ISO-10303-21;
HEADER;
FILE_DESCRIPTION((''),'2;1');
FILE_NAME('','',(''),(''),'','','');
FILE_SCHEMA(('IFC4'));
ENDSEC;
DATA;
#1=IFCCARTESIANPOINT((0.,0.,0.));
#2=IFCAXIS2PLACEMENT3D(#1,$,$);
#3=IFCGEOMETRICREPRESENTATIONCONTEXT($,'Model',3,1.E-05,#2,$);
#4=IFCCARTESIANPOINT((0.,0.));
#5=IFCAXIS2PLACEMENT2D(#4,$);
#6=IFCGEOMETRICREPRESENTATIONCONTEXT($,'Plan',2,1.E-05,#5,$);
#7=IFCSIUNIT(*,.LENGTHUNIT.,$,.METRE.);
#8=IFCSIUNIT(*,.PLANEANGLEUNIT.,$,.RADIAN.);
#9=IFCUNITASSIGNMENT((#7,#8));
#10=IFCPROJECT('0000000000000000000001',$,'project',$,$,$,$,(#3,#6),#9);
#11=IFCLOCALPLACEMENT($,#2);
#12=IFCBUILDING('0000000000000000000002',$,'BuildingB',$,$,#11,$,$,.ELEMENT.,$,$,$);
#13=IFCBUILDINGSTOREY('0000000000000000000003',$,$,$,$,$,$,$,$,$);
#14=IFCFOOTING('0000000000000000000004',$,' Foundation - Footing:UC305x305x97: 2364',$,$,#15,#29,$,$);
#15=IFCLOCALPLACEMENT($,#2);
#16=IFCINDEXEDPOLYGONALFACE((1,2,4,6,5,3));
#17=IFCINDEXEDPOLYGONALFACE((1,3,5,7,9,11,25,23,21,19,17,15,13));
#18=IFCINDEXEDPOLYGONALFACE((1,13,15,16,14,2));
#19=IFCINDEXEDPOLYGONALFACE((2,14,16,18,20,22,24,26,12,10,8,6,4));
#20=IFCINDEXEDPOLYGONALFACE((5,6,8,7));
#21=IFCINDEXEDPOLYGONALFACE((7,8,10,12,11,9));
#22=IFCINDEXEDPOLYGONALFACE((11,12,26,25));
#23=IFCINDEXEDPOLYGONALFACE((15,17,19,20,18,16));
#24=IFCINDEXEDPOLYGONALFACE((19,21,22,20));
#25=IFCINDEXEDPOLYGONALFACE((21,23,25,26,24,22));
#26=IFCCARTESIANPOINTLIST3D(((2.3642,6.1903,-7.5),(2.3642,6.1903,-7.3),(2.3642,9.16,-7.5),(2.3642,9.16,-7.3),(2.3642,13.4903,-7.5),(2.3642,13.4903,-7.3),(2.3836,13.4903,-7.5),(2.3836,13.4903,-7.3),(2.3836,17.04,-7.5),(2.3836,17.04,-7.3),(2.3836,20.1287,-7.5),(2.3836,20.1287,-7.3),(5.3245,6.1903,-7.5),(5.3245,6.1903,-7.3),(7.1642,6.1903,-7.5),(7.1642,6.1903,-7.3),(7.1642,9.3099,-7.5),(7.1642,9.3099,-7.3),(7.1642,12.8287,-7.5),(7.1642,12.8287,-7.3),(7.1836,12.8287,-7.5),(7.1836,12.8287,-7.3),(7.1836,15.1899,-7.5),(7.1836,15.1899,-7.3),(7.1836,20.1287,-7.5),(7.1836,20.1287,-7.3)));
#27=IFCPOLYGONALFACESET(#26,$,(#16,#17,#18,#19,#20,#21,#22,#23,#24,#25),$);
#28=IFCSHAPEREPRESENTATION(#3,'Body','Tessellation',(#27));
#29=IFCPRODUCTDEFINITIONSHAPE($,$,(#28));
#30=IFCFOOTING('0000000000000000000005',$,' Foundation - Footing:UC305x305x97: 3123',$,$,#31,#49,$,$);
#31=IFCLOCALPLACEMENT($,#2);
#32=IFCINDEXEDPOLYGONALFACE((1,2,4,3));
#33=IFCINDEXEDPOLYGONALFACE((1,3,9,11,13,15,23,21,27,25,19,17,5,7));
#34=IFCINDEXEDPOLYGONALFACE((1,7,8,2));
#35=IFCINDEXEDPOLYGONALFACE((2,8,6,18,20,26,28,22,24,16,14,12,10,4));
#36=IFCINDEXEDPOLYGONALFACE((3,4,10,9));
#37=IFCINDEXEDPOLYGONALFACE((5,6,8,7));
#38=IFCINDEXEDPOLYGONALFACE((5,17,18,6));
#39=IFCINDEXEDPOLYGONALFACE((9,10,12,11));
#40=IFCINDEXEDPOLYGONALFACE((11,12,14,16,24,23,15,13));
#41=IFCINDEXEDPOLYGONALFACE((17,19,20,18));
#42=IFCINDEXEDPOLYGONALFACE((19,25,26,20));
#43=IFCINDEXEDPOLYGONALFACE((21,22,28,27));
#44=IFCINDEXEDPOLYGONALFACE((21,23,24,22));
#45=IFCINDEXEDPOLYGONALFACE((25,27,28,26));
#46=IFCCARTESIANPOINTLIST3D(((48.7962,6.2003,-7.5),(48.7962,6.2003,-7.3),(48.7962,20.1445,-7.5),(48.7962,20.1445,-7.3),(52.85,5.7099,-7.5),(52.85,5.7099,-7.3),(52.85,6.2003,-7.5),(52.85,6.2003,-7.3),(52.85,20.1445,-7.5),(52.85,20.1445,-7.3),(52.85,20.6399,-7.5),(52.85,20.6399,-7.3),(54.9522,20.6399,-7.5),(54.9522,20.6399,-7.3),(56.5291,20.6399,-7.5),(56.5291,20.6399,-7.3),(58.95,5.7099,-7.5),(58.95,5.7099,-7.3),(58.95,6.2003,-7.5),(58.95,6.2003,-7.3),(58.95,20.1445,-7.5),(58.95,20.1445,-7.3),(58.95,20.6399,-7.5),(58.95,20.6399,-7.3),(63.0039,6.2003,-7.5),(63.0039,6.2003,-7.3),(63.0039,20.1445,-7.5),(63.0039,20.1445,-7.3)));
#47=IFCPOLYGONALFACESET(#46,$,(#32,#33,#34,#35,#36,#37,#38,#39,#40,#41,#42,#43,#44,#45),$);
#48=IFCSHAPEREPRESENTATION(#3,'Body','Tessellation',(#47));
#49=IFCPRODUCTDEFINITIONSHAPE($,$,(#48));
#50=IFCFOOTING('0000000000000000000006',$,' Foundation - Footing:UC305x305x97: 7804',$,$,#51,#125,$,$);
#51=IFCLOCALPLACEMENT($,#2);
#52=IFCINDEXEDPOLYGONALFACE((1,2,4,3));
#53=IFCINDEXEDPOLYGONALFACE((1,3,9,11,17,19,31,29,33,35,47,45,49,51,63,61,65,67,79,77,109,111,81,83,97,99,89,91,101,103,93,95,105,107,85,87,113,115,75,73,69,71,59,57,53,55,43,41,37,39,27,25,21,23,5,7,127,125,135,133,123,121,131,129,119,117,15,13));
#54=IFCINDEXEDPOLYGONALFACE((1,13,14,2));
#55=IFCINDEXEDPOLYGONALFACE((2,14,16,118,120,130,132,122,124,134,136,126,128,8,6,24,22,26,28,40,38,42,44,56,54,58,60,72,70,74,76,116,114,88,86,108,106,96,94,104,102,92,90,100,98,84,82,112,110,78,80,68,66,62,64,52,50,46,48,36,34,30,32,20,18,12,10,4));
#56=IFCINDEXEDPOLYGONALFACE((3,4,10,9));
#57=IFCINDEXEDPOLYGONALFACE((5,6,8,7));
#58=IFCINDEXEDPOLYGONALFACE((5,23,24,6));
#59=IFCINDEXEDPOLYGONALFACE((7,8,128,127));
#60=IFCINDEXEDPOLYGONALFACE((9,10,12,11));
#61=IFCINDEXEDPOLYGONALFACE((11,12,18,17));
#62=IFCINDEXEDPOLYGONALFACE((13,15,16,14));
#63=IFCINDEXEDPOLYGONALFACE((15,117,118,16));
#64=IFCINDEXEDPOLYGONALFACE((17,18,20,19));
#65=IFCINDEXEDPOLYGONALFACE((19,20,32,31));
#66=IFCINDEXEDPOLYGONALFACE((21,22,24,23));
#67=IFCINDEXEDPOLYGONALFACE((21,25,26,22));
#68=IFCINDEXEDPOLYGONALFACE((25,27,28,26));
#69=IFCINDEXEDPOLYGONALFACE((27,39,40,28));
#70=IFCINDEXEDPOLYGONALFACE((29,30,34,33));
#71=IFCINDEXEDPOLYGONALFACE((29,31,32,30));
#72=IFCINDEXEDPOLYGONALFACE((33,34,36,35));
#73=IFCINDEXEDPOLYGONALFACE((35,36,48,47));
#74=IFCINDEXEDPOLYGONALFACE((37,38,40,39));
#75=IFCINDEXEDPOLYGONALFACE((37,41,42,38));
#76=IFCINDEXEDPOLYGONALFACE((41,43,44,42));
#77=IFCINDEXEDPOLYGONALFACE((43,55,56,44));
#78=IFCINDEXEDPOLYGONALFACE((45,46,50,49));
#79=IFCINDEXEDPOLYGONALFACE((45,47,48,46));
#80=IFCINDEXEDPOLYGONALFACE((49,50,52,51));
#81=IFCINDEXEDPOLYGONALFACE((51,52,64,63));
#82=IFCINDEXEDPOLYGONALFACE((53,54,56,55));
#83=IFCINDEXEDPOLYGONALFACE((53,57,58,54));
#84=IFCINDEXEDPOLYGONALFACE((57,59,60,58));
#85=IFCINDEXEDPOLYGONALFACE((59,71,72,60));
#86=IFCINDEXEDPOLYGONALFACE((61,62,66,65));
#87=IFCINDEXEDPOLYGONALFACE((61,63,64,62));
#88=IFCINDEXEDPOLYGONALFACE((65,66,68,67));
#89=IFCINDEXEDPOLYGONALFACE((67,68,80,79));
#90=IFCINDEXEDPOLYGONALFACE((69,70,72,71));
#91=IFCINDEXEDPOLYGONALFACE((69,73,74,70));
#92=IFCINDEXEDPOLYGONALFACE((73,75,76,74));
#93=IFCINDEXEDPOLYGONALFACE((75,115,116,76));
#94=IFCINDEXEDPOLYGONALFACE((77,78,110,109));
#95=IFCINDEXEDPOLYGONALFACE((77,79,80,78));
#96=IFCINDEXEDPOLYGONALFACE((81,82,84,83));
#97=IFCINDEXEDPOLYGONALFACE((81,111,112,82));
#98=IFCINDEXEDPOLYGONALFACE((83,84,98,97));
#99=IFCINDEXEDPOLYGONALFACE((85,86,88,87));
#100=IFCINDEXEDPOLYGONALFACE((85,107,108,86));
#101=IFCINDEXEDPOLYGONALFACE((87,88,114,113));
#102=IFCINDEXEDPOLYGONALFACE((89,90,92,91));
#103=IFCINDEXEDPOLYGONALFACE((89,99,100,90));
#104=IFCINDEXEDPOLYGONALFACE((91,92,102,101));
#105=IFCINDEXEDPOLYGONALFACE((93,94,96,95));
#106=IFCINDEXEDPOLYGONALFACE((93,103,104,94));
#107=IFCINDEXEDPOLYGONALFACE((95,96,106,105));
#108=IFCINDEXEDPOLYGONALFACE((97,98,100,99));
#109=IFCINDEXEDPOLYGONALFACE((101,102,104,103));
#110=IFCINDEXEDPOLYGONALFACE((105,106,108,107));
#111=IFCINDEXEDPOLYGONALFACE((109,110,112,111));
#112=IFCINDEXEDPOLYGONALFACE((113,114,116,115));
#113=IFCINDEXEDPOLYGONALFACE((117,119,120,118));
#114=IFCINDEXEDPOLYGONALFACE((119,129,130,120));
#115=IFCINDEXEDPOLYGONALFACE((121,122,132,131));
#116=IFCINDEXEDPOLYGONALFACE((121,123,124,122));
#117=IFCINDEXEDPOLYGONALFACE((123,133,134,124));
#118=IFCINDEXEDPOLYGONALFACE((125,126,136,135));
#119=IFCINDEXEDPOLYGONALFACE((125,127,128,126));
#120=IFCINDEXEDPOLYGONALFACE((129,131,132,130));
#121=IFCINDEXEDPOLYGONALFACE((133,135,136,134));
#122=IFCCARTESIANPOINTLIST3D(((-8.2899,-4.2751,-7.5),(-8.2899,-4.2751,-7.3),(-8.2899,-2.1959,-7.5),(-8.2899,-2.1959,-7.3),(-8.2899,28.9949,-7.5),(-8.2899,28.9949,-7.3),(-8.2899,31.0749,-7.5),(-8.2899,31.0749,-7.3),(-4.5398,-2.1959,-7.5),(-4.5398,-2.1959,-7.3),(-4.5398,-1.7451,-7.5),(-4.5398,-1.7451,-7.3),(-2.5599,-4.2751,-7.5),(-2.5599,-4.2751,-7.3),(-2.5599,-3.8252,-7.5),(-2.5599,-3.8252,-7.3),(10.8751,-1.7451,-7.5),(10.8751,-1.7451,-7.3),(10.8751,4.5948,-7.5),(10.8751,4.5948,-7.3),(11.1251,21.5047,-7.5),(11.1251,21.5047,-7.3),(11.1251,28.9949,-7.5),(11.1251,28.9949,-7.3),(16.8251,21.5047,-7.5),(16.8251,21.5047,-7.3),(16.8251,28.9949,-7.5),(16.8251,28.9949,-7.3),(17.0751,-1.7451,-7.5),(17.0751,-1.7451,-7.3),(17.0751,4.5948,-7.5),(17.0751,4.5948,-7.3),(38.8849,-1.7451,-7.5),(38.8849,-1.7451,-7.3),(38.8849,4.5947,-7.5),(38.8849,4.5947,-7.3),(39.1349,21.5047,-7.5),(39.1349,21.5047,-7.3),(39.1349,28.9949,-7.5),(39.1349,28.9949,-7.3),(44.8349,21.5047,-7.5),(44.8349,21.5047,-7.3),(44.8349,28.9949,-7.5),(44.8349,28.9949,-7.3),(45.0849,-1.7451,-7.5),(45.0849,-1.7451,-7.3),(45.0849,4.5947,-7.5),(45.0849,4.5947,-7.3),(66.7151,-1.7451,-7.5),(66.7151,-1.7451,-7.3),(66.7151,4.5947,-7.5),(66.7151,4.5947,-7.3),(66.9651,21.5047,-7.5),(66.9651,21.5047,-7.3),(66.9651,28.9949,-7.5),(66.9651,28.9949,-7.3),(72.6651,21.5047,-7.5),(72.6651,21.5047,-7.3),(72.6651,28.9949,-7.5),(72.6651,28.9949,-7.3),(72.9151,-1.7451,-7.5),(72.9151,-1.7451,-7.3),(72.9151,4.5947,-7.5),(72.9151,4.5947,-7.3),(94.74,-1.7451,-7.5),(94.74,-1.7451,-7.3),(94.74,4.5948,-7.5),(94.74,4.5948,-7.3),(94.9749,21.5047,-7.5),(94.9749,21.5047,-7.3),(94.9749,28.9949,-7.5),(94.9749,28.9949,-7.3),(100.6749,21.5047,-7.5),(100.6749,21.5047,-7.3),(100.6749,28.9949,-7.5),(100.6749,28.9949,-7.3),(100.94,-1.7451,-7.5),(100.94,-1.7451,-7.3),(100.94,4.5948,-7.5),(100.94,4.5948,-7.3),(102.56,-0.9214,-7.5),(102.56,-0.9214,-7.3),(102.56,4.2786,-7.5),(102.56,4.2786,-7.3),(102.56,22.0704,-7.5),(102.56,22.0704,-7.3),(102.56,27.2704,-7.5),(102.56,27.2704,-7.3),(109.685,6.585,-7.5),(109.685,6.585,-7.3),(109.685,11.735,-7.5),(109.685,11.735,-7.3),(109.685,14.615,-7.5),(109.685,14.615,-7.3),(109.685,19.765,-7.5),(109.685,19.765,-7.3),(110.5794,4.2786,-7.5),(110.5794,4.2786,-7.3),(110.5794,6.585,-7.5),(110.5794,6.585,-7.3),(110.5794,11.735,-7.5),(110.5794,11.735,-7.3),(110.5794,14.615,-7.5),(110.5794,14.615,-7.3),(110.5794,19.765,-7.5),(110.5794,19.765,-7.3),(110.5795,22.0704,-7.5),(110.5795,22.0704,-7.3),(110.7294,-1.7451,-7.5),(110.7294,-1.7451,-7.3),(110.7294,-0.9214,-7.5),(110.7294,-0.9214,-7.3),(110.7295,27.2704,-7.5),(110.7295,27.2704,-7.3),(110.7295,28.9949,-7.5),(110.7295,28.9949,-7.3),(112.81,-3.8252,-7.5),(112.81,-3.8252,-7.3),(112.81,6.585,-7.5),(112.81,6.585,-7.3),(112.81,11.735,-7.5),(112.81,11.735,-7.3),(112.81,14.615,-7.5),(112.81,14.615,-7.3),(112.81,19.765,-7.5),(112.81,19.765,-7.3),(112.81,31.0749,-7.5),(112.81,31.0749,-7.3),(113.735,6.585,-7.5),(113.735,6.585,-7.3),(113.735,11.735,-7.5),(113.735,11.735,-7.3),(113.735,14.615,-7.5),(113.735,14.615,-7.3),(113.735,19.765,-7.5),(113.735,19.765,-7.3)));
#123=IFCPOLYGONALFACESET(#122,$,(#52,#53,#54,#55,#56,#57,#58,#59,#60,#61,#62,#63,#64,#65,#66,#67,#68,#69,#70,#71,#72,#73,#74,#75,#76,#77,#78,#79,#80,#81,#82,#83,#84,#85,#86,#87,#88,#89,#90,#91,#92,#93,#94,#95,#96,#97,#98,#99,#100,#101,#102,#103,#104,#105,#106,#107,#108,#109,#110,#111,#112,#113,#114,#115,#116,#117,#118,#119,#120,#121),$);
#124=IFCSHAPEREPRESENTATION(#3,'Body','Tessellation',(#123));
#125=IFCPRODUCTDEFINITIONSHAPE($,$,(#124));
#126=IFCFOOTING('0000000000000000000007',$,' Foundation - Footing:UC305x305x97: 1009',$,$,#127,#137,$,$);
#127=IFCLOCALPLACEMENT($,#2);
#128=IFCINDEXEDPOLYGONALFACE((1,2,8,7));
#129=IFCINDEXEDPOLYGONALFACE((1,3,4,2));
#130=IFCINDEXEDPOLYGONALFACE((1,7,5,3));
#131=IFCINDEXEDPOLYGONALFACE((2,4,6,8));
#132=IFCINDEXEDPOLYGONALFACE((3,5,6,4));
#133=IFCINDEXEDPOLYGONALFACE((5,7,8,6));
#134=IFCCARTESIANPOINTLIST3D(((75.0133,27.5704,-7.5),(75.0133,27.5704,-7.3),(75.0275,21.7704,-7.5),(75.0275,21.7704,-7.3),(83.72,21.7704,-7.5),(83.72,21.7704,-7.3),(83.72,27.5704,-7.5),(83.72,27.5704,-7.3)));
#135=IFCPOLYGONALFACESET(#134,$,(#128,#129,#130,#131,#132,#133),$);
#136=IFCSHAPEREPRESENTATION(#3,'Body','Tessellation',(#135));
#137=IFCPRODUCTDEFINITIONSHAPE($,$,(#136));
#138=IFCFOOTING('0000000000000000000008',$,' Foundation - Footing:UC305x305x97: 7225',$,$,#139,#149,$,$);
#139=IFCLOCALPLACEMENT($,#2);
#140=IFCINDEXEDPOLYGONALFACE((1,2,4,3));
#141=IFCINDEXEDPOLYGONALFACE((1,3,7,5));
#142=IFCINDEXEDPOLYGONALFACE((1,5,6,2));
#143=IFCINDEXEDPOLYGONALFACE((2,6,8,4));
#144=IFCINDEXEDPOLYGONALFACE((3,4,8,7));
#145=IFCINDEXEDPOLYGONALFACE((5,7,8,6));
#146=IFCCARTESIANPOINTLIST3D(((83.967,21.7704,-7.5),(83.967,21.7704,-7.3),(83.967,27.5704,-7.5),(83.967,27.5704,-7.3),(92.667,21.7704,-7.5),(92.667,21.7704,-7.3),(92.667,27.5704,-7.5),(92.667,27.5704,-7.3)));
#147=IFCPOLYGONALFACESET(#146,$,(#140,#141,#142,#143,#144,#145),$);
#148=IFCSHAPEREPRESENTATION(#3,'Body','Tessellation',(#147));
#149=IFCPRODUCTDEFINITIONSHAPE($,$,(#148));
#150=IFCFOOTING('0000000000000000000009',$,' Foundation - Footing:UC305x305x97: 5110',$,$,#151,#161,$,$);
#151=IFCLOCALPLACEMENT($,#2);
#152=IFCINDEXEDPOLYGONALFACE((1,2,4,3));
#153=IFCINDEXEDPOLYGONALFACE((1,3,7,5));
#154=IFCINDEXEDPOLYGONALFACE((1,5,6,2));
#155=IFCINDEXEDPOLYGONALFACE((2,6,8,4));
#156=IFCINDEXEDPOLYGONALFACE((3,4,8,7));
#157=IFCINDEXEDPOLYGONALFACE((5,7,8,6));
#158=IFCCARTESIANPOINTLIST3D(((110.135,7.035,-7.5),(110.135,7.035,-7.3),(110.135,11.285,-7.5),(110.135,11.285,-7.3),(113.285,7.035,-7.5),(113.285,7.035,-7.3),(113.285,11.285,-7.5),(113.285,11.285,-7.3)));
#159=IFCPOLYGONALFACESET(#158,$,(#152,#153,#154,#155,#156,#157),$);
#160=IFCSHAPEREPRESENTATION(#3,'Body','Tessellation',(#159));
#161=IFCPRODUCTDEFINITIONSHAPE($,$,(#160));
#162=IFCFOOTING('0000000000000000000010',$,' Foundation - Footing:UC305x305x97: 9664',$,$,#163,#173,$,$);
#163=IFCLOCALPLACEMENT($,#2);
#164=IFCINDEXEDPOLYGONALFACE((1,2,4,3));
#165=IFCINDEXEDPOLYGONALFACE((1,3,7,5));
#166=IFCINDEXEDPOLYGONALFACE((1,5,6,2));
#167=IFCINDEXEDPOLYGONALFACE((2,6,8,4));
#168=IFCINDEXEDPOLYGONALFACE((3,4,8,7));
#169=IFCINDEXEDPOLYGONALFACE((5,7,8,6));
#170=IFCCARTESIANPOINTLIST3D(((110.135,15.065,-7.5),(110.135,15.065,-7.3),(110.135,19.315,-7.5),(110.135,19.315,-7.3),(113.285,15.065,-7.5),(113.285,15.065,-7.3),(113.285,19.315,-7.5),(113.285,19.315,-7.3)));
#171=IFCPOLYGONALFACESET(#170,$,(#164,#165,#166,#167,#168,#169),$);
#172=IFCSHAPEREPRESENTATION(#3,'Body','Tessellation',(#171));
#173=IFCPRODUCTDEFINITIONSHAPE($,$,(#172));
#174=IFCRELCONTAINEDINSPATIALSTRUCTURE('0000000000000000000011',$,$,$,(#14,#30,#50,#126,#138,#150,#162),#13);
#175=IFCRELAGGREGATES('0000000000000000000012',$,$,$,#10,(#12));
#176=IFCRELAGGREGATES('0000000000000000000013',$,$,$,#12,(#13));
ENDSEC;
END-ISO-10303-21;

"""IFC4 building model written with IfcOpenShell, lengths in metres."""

from ifc_helpers import new_model, si_unit, origin, origin_2d, place, context, project, spatial, polyline, outline, extrude, element, save


model = new_model("IFC4")

# Units and contexts
model_context = context("Model", 3, precision=1e-05, world=origin())
plan_context = context("Plan", 2, precision=1e-05, world=origin_2d())
ifc_project = project(units=[si_unit("LENGTHUNIT", "METRE"), si_unit("PLANEANGLEUNIT", "RADIAN")], contexts=[model_context, plan_context])

# Building, storey
building_placement = place(None, origin())
building = spatial("IfcBuilding", under=ifc_project, at=building_placement, Name="BuildingB", CompositionType="ELEMENT")
storey = spatial("IfcBuildingStorey", under=building)

# Footings
element("IfcFooting", 1, inside=storey, Name=" Foundation - Footing:UC305x305x97: 2364", context=model_context, shape_type="SweptSolid", body=[
    extrude(outline(polyline([(7.1642, 12.8287, -7.5), (7.1836, 12.8287, -7.5), (7.1836, 15.1899, -7.5), (7.1836, 20.1287, -7.5), (2.3836, 20.1287, -7.5), (2.3836, 17.04, -7.5), (2.3836, 13.4903, -7.5), (2.3642, 13.4903, -7.5), (2.3642, 9.16, -7.5), (2.3642, 6.1903, -7.5), (5.3245, 6.1903, -7.5), (7.1642, 6.1903, -7.5), (7.1642, 9.3099, -7.5), (7.1642, 12.8287, -7.5)])), None, (0.0, 0.0, 1.0), 0.2),
])
element("IfcFooting", 2, inside=storey, Name=" Foundation - Footing:UC305x305x97: 3123", context=model_context, shape_type="SweptSolid", body=[
    extrude(outline(polyline([(58.95, 5.7099, -7.5), (58.95, 6.2003, -7.5), (63.0039, 6.2003, -7.5), (63.0039, 20.1445, -7.5), (58.95, 20.1445, -7.5), (58.95, 20.6399, -7.5), (56.5291, 20.6399, -7.5), (54.9522, 20.6399, -7.5), (52.85, 20.6399, -7.5), (52.85, 20.1445, -7.5), (48.7962, 20.1445, -7.5), (48.7962, 6.2003, -7.5), (52.85, 6.2003, -7.5), (52.85, 5.7099, -7.5), (58.95, 5.7099, -7.5)])), None, (0.0, 0.0, 1.0), 0.2),
])
element("IfcFooting", 3, inside=storey, Name=" Foundation - Footing:UC305x305x97: 7804", context=model_context, shape_type="SweptSolid", body=[
    extrude(outline(polyline([(-8.2899, 31.0749, -7.5), (-8.2899, 28.9949, -7.5), (11.1251, 28.9949, -7.5), (11.1251, 21.5047, -7.5), (16.8251, 21.5047, -7.5), (16.8251, 28.9949, -7.5), (39.1349, 28.9949, -7.5), (39.1349, 21.5047, -7.5), (44.8349, 21.5047, -7.5), (44.8349, 28.9949, -7.5), (66.9651, 28.9949, -7.5), (66.9651, 21.5047, -7.5), (72.6651, 21.5047, -7.5), (72.6651, 28.9949, -7.5), (94.9749, 28.9949, -7.5), (94.9749, 21.5047, -7.5), (100.6749, 21.5047, -7.5), (100.6749, 28.9949, -7.5), (110.7295, 28.9949, -7.5), (110.7295, 27.2704, -7.5), (102.56, 27.2704, -7.5), (102.56, 22.0704, -7.5), (110.5795, 22.0704, -7.5), (110.5794, 19.765, -7.5), (109.685, 19.765, -7.5), (109.685, 14.615, -7.5), (110.5794, 14.615, -7.5), (110.5794, 11.735, -7.5), (109.685, 11.735, -7.5), (109.685, 6.585, -7.5), (110.5794, 6.585, -7.5), (110.5794, 4.2786, -7.5), (102.56, 4.2786, -7.5), (102.56, -0.9214, -7.5), (110.7294, -0.9214, -7.5), (110.7294, -1.7451, -7.5), (100.94, -1.7451, -7.5), (100.94, 4.5948, -7.5), (94.74, 4.5948, -7.5), (94.74, -1.7451, -7.5), (72.9151, -1.7451, -7.5), (72.9151, 4.5947, -7.5), (66.7151, 4.5947, -7.5), (66.7151, -1.7451, -7.5), (45.0849, -1.7451, -7.5), (45.0849, 4.5947, -7.5), (38.8849, 4.5947, -7.5), (38.8849, -1.7451, -7.5), (17.0751, -1.7451, -7.5), (17.0751, 4.5948, -7.5), (10.8751, 4.5948, -7.5), (10.8751, -1.7451, -7.5), (-4.5398, -1.7451, -7.5), (-4.5398, -2.1959, -7.5), (-8.2899, -2.1959, -7.5), (-8.2899, -4.2751, -7.5), (-2.5599, -4.2751, -7.5), (-2.5599, -3.8252, -7.5), (112.81, -3.8252, -7.5), (112.81, 6.585, -7.5), (113.735, 6.585, -7.5), (113.735, 11.735, -7.5), (112.81, 11.735, -7.5), (112.81, 14.615, -7.5), (113.735, 14.615, -7.5), (113.735, 19.765, -7.5), (112.81, 19.765, -7.5), (112.81, 31.0749, -7.5), (-8.2899, 31.0749, -7.5)])), None, (0.0, 0.0, 1.0), 0.2),
])
element("IfcFooting", 4, inside=storey, Name=" Foundation - Footing:UC305x305x97: 1009", context=model_context, shape_type="SweptSolid", body=[
    extrude(outline(polyline([(75.0275, 21.7704, -7.5), (83.72, 21.7704, -7.5), (83.72, 27.5704, -7.5), (75.0133, 27.5704, -7.5), (75.0275, 21.7704, -7.5)])), None, (0.0, 0.0, 1.0), 0.2),
])
element("IfcFooting", 5, inside=storey, Name=" Foundation - Footing:UC305x305x97: 7225", context=model_context, shape_type="SweptSolid", body=[
    extrude(outline(polyline([(83.967, 21.7704, -7.5), (92.667, 21.7704, -7.5), (92.667, 27.5704, -7.5), (83.967, 27.5704, -7.5), (83.967, 21.7704, -7.5)])), None, (0.0, 0.0, 1.0), 0.2),
])
element("IfcFooting", 6, inside=storey, Name=" Foundation - Footing:UC305x305x97: 5110", context=model_context, shape_type="SweptSolid", body=[
    extrude(outline(polyline([(110.135, 11.285, -7.5), (113.285, 11.285, -7.5), (113.285, 7.035, -7.5), (110.135, 7.035, -7.5), (110.135, 11.285, -7.5)])), None, (0.0, 0.0, 1.0), 0.2),
])
element("IfcFooting", 7, inside=storey, Name=" Foundation - Footing:UC305x305x97: 9664", context=model_context, shape_type="SweptSolid", body=[
    extrude(outline(polyline([(110.135, 19.315, -7.5), (113.285, 19.315, -7.5), (113.285, 15.065, -7.5), (110.135, 15.065, -7.5), (110.135, 19.315, -7.5)])), None, (0.0, 0.0, 1.0), 0.2),
])

save(model, "model.ifc")
